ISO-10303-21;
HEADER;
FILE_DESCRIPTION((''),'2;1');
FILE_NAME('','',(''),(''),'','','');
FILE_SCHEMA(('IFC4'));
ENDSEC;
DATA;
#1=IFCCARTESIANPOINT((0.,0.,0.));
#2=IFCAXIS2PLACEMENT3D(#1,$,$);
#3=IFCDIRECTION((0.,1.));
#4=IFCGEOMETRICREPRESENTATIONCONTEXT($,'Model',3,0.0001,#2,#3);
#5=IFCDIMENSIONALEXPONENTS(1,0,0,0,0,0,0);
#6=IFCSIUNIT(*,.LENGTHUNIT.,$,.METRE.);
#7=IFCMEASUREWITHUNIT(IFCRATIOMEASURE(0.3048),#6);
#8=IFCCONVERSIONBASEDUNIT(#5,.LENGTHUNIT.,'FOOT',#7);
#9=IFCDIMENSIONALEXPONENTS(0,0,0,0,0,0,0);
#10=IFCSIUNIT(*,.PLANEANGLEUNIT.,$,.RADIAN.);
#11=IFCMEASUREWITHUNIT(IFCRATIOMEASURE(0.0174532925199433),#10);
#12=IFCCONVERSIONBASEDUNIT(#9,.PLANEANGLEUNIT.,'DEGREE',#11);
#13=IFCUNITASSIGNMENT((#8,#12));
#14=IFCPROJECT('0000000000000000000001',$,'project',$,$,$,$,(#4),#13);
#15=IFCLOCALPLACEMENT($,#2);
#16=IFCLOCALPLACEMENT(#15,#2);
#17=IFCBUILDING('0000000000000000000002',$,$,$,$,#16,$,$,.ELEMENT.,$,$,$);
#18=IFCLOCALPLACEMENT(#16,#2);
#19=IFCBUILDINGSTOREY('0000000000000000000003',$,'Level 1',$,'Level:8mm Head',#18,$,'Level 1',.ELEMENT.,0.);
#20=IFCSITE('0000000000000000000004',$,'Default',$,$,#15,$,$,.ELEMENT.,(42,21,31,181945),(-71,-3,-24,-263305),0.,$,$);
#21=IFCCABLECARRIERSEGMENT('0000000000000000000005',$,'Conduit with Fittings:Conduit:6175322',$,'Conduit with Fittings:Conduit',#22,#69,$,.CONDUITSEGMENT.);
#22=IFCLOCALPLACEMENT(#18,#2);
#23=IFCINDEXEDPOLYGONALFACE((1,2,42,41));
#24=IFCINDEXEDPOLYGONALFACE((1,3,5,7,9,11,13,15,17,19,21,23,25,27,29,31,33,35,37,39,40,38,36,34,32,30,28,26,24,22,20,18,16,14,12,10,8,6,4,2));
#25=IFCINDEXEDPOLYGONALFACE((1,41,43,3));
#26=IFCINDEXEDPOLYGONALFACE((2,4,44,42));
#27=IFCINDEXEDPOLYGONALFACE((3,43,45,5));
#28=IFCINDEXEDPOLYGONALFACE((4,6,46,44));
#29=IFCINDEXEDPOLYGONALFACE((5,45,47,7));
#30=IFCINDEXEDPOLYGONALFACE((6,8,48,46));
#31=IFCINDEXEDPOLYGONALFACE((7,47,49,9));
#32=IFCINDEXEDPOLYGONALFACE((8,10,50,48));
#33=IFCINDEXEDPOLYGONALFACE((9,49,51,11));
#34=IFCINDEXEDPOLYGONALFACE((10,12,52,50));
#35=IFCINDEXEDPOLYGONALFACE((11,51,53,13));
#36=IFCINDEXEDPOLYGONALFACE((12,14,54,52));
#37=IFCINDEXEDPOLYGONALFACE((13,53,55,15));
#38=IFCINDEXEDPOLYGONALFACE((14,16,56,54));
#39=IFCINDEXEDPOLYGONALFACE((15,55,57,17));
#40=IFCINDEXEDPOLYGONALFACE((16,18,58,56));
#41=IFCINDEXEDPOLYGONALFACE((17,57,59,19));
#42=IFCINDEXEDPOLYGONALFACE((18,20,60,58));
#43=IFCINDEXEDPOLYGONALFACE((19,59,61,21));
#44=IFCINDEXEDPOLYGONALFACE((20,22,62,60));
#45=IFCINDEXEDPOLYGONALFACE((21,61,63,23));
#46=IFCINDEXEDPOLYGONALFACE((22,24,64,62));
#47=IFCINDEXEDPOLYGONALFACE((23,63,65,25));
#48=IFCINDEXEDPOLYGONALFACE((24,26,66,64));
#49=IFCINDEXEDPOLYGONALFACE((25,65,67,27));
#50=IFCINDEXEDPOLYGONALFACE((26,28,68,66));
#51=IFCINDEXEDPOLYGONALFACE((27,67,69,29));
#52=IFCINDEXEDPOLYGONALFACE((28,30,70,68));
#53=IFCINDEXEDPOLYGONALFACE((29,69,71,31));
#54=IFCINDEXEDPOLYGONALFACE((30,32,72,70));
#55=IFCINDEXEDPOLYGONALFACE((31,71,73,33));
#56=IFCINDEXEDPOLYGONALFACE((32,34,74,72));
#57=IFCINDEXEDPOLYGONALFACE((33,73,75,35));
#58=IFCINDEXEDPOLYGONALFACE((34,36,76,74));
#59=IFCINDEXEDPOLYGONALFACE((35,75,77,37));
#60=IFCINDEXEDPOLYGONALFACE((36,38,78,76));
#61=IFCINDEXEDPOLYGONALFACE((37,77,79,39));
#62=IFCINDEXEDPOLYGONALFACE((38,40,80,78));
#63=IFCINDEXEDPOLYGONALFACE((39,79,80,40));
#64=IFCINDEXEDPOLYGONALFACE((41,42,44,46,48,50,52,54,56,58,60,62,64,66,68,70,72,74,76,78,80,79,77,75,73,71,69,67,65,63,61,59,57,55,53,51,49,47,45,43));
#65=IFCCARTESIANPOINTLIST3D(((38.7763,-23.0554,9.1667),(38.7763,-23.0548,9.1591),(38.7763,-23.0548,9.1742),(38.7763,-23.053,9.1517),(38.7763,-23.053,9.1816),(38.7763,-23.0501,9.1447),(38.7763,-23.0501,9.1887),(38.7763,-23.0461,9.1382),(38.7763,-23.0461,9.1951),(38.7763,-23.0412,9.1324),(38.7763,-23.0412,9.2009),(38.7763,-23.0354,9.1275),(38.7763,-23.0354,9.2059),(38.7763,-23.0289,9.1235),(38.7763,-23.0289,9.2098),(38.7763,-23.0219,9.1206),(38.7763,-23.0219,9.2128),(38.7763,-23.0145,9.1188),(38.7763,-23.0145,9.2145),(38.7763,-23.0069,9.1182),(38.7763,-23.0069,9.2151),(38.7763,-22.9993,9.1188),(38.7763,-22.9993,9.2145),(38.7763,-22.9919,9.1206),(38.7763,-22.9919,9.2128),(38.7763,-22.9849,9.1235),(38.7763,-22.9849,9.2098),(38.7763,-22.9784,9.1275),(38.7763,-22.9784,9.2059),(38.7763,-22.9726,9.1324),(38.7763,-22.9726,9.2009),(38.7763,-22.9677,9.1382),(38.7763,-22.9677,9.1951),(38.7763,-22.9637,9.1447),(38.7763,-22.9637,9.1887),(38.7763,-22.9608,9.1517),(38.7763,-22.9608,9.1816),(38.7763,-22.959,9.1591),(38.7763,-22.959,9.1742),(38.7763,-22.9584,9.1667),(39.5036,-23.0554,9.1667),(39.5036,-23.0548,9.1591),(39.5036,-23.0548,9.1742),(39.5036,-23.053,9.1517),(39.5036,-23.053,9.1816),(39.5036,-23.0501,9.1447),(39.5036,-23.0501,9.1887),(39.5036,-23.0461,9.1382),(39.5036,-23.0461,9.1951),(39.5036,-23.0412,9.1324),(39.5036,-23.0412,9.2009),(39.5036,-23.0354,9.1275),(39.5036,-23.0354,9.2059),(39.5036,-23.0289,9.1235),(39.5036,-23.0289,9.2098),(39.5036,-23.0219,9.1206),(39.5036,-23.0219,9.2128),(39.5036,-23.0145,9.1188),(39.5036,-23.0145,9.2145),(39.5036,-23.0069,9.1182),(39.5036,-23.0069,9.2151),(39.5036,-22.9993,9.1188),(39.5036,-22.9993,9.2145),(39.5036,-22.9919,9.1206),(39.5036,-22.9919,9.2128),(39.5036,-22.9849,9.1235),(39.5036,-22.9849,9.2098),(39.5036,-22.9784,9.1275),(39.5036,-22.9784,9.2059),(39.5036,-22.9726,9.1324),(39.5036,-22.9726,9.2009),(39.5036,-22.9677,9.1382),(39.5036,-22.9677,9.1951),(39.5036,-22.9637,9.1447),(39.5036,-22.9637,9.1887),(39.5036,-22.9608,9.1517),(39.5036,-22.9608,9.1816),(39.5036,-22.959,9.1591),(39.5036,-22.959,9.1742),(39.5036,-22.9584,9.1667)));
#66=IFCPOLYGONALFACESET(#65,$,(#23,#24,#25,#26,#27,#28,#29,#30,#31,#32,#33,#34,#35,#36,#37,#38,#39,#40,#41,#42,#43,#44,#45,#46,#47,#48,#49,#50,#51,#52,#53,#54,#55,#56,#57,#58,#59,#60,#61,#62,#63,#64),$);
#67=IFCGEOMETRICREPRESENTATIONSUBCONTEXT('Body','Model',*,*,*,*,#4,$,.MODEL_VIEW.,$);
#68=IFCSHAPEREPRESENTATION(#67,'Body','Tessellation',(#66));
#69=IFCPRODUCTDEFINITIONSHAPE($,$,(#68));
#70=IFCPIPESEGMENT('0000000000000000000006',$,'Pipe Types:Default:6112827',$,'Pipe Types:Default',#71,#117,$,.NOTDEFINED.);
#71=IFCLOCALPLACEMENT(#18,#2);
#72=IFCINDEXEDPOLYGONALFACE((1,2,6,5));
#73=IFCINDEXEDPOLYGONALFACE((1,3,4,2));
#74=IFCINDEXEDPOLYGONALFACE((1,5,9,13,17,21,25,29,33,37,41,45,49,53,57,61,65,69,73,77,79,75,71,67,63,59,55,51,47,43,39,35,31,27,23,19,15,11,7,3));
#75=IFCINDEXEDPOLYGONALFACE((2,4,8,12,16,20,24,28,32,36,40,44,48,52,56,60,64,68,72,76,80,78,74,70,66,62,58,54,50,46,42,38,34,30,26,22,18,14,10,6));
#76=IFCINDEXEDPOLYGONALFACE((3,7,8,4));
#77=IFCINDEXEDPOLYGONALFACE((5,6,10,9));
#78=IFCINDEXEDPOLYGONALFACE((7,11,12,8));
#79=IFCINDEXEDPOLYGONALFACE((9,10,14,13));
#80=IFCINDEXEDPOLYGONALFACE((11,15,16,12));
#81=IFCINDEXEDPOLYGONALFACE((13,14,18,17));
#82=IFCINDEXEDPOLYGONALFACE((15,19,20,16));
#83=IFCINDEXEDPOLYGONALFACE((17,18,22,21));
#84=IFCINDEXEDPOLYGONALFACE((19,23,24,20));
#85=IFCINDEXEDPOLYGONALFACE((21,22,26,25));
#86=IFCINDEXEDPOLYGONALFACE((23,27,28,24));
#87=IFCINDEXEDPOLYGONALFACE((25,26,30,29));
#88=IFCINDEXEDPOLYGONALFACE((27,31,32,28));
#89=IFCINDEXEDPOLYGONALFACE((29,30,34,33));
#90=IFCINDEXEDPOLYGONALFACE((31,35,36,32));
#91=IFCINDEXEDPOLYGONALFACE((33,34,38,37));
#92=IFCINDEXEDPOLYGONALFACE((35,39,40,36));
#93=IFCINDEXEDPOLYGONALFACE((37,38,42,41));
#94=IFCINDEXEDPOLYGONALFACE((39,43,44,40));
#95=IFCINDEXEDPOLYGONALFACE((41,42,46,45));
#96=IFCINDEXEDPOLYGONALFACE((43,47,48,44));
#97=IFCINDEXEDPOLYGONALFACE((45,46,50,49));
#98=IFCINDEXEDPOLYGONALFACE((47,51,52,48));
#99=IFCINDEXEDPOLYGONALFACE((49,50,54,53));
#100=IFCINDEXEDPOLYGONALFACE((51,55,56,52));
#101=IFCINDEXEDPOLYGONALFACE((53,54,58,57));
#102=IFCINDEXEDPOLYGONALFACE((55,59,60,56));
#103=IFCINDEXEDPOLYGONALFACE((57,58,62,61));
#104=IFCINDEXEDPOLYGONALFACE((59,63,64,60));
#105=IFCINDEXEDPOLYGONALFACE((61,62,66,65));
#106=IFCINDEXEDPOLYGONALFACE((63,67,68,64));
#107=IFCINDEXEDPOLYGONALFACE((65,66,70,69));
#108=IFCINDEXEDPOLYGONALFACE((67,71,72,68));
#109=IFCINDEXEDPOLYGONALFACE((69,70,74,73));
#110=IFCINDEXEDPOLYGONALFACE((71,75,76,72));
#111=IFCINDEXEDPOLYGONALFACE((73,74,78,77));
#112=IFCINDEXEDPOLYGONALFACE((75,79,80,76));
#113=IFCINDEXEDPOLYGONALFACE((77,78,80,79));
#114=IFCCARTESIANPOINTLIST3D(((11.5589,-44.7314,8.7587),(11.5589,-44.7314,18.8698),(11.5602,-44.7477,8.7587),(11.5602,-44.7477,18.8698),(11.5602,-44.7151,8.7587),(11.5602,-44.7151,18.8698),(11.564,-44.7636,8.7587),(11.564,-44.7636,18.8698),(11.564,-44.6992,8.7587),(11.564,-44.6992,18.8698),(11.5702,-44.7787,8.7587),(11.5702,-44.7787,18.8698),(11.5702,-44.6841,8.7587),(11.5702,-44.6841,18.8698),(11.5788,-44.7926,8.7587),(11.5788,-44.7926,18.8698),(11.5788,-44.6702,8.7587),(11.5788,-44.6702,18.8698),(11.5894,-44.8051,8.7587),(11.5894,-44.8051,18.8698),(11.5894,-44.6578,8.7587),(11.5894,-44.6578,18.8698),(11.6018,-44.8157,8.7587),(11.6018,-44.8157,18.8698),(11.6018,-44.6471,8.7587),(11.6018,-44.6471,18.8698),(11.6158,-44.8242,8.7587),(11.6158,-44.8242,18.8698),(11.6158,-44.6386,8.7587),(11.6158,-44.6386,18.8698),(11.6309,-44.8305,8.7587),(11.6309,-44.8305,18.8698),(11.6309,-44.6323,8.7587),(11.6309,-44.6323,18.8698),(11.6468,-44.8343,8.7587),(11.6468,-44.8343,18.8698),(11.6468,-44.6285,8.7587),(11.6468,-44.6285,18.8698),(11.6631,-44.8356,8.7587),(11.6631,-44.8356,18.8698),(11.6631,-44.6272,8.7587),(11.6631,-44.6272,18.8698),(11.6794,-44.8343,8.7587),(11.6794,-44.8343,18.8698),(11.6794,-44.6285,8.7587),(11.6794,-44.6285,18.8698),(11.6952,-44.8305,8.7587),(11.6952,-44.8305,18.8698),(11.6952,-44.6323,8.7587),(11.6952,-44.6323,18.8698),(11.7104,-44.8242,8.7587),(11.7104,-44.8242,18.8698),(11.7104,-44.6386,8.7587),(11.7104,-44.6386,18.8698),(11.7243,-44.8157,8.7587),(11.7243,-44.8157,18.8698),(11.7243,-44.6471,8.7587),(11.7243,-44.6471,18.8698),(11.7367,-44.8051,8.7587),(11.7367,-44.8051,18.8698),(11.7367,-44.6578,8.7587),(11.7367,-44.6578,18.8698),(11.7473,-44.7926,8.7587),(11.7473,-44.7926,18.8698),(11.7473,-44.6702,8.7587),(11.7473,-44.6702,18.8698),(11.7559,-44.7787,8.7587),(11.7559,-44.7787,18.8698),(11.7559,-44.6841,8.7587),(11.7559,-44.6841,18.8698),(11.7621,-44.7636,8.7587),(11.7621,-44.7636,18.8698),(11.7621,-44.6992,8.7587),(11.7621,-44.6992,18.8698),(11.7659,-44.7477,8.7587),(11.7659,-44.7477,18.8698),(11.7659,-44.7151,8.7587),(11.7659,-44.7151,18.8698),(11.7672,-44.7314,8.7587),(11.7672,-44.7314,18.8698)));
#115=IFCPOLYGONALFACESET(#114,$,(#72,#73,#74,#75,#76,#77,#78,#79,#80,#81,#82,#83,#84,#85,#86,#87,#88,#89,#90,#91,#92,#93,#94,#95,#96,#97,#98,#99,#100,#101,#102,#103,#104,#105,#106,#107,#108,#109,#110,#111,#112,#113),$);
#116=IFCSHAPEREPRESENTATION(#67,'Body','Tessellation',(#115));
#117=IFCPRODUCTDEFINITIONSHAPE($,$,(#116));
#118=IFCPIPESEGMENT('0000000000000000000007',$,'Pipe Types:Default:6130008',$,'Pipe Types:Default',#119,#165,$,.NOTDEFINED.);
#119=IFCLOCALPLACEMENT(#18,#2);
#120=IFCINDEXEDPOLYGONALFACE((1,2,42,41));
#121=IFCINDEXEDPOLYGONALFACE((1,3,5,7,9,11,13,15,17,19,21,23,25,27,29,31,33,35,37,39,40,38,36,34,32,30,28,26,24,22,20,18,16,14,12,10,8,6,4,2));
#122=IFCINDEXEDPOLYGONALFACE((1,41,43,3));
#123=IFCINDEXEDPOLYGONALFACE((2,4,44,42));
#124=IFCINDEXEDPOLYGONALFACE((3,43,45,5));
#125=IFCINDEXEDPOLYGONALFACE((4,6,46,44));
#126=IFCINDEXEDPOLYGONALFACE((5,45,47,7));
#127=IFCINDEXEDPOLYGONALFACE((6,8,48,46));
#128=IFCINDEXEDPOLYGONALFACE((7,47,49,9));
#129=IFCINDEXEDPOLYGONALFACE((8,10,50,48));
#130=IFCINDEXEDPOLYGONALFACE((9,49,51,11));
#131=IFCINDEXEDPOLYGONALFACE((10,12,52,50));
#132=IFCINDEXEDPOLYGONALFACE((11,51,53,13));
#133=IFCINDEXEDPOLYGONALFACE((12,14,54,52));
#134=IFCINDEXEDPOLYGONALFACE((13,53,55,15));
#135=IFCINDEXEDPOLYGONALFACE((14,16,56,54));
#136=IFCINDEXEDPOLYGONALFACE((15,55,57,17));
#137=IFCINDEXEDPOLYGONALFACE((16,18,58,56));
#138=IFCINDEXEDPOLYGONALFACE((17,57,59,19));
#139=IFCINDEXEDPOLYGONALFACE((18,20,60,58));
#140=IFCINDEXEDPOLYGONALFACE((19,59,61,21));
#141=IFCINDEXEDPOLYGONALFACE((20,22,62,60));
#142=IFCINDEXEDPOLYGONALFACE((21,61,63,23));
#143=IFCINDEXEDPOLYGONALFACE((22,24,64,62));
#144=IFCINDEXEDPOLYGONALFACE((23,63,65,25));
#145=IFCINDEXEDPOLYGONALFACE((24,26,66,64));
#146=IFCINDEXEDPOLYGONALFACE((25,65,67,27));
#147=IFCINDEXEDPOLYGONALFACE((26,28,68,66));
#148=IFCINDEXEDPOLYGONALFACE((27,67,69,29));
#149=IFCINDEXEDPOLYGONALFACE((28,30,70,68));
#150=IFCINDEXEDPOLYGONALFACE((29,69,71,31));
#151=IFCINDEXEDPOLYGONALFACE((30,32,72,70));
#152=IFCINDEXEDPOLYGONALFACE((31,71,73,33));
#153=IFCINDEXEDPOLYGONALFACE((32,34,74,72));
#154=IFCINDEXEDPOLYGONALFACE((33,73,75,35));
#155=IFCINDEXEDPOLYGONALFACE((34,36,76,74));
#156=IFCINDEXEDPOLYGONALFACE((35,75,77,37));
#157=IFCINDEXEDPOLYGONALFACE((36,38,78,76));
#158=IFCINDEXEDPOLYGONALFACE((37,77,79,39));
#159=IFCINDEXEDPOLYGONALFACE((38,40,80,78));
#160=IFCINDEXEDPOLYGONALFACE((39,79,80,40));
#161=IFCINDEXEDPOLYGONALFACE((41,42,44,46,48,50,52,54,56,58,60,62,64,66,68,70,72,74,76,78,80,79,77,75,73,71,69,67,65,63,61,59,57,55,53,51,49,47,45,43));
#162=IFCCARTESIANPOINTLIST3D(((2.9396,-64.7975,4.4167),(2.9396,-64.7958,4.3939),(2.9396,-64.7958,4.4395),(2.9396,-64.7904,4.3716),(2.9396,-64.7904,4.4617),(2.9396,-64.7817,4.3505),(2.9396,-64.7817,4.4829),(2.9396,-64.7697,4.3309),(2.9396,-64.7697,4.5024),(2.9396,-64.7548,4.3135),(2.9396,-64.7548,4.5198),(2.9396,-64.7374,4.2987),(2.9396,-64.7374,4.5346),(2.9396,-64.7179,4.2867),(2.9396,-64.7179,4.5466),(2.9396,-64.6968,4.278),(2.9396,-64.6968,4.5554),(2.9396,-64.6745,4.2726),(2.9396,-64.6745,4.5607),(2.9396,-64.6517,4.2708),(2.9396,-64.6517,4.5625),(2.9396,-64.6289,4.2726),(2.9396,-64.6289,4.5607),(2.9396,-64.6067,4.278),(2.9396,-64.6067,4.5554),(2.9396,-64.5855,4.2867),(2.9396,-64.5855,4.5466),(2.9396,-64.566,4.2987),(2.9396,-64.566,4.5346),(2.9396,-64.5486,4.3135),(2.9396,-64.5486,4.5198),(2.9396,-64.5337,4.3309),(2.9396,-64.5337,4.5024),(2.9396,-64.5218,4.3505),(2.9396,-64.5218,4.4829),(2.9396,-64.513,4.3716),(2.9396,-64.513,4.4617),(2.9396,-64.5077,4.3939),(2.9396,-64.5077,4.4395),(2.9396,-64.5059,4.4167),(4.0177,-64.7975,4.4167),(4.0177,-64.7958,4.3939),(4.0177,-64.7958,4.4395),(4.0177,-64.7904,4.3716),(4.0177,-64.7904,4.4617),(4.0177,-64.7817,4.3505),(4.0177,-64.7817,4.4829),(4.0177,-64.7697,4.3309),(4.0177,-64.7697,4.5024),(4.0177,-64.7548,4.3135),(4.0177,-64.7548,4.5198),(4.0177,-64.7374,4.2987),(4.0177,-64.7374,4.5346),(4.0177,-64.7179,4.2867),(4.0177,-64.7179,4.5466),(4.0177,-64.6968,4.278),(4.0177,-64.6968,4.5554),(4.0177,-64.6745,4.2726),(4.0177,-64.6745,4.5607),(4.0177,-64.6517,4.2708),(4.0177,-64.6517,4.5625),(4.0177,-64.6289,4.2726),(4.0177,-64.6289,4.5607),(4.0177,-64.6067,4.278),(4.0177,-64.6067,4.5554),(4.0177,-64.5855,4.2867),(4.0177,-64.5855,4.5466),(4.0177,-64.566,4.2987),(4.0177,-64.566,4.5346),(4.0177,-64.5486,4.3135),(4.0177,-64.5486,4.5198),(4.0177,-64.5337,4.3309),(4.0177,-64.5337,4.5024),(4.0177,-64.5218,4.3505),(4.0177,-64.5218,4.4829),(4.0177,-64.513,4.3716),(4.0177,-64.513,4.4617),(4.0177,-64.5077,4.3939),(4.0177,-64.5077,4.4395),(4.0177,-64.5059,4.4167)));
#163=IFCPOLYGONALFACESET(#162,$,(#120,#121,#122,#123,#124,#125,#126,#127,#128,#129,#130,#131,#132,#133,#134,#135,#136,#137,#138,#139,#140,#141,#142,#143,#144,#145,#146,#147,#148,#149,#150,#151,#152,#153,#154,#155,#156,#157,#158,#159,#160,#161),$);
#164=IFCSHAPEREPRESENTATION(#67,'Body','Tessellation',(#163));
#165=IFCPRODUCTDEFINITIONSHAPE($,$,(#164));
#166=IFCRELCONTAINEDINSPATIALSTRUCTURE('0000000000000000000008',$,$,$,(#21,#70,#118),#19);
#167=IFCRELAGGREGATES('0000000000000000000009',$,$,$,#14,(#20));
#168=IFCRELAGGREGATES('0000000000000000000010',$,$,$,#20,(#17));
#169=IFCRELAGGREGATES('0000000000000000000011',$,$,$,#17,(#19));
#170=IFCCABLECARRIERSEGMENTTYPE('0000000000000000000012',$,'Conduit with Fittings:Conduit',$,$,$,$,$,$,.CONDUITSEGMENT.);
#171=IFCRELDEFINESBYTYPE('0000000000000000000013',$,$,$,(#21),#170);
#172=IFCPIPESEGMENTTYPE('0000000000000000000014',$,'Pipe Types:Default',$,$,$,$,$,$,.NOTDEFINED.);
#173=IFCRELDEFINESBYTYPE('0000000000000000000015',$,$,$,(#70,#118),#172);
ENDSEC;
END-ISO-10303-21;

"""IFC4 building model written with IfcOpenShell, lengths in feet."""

from ifc_helpers import new_model, entity, si_unit, converted_unit, direction, frame, origin, place, context, subcontext, project, spatial, indexed_curve, outline, extrude, type_object, element, save


model = new_model("IFC4")

# Units and contexts
model_context = context("Model", 3, precision=0.0001, world=origin(), true_north=direction((0.0, 1.0)))
body_context = subcontext(model_context, "Body", "Model", "MODEL_VIEW")
ifc_project = project(units=[converted_unit("LENGTHUNIT", "FOOT", entity("IfcRatioMeasure", 0.3048), si_unit("LENGTHUNIT", "METRE"), dimensions=[1, 0, 0, 0, 0, 0, 0]), converted_unit("PLANEANGLEUNIT", "DEGREE", entity("IfcRatioMeasure", 0.0174532925199433), si_unit("PLANEANGLEUNIT", "RADIAN"), dimensions=[0, 0, 0, 0, 0, 0, 0])], contexts=[model_context])

# Site, building, storey
site_placement = place(None, origin())
site = spatial("IfcSite", under=ifc_project, at=site_placement, Name="Default", CompositionType="ELEMENT", RefLatitude=(42, 21, 31, 181945), RefLongitude=(-71, -3, -24, -263305), RefElevation=0.0)
building_placement = place(site_placement, origin())
building = spatial("IfcBuilding", under=site, at=building_placement, CompositionType="ELEMENT")
storey_placement = place(building_placement, origin())
storey = spatial("IfcBuildingStorey", under=building, at=storey_placement, Name="Level 1", ObjectType="Level:8mm Head", LongName="Level 1", CompositionType="ELEMENT", Elevation=0.0)

# Cable carrier segment
cable_carrier_segment_type_1 = type_object("IfcCableCarrierSegmentType", Name="Conduit with Fittings:Conduit", PredefinedType="CONDUITSEGMENT")
cable_carrier_segment_1_placement = place(storey_placement, origin())
element("IfcCableCarrierSegment", 1, at=cable_carrier_segment_1_placement, inside=storey, type_object=cable_carrier_segment_type_1, Name="Conduit with Fittings:Conduit:6175322", ObjectType="Conduit with Fittings:Conduit", PredefinedType="CONDUITSEGMENT", context=body_context, shape_type="SweptSolid", body=[
    extrude(outline(indexed_curve([(0.0485, 0.0), (0.0479, 0.0076), (0.0461, 0.015), (0.0432, 0.022), (0.0392, 0.0285), (0.0343, 0.0343), (0.0285, 0.0392), (0.022, 0.0432), (0.015, 0.0461), (0.0076, 0.0479), (0.0, 0.0485), (-0.0076, 0.0479), (-0.015, 0.0461), (-0.022, 0.0432), (-0.0285, 0.0392), (-0.0343, 0.0343), (-0.0392, 0.0285), (-0.0432, 0.022), (-0.0461, 0.015), (-0.0479, 0.0076), (-0.0485, 0.0), (-0.0479, -0.0076), (-0.0461, -0.015), (-0.0432, -0.022), (-0.0392, -0.0285), (-0.0343, -0.0343), (-0.0285, -0.0392), (-0.022, -0.0432), (-0.015, -0.0461), (-0.0076, -0.0479), (0.0, -0.0485), (0.0076, -0.0479), (0.015, -0.0461), (0.022, -0.0432), (0.0285, -0.0392), (0.0343, -0.0343), (0.0392, -0.0285), (0.0432, -0.022), (0.0461, -0.015), (0.0479, -0.0076), (0.0485, 0.0)], self_intersect=False)), frame((38.7763, -23.0069, 9.1667), z_axis=(1.0, 0.0, 0.0), x_axis=(0.0, -1.0, 0.0)), (0.0, 0.0, 1.0), 0.7272),
])

# Pipe segments
pipe_segment_type = type_object("IfcPipeSegmentType", Name="Pipe Types:Default", PredefinedType="NOTDEFINED")
pipe_segment_1_placement = place(storey_placement, origin())
element("IfcPipeSegment", 2, at=pipe_segment_1_placement, inside=storey, type_object=pipe_segment_type, Name="Pipe Types:Default:6112827", ObjectType="Pipe Types:Default", PredefinedType="NOTDEFINED", context=body_context, shape_type="SweptSolid", body=[
    extrude(outline(indexed_curve([(0.1042, 0.0), (0.1029, 0.0163), (0.0991, 0.0322), (0.0928, 0.0473), (0.0843, 0.0612), (0.0737, 0.0737), (0.0612, 0.0843), (0.0473, 0.0928), (0.0322, 0.0991), (0.0163, 0.1029), (0.0, 0.1042), (-0.0163, 0.1029), (-0.0322, 0.0991), (-0.0473, 0.0928), (-0.0612, 0.0843), (-0.0737, 0.0737), (-0.0843, 0.0612), (-0.0928, 0.0473), (-0.0991, 0.0322), (-0.1029, 0.0163), (-0.1042, 0.0), (-0.1029, -0.0163), (-0.0991, -0.0322), (-0.0928, -0.0473), (-0.0843, -0.0612), (-0.0737, -0.0737), (-0.0612, -0.0843), (-0.0473, -0.0928), (-0.0322, -0.0991), (-0.0163, -0.1029), (0.0, -0.1042), (0.0163, -0.1029), (0.0322, -0.0991), (0.0473, -0.0928), (0.0612, -0.0843), (0.0737, -0.0737), (0.0843, -0.0612), (0.0928, -0.0473), (0.0991, -0.0322), (0.1029, -0.0163), (0.1042, 0.0)], self_intersect=False)), frame((11.6631, -44.7314, 8.7587)), (0.0, 0.0, 1.0), 10.111),
])
pipe_segment_2_placement = place(storey_placement, origin())
element("IfcPipeSegment", 3, at=pipe_segment_2_placement, inside=storey, type_object=pipe_segment_type, Name="Pipe Types:Default:6130008", ObjectType="Pipe Types:Default", PredefinedType="NOTDEFINED", context=body_context, shape_type="SweptSolid", body=[
    extrude(outline(indexed_curve([(0.1458, 0.0), (0.144, 0.0228), (0.1387, 0.0451), (0.1299, 0.0662), (0.118, 0.0857), (0.1031, 0.1031), (0.0857, 0.118), (0.0662, 0.1299), (0.0451, 0.1387), (0.0228, 0.144), (0.0, 0.1458), (-0.0228, 0.144), (-0.0451, 0.1387), (-0.0662, 0.1299), (-0.0857, 0.118), (-0.1031, 0.1031), (-0.118, 0.0857), (-0.1299, 0.0662), (-0.1387, 0.0451), (-0.144, 0.0228), (-0.1458, 0.0), (-0.144, -0.0228), (-0.1387, -0.0451), (-0.1299, -0.0662), (-0.118, -0.0857), (-0.1031, -0.1031), (-0.0857, -0.118), (-0.0662, -0.1299), (-0.0451, -0.1387), (-0.0228, -0.144), (0.0, -0.1458), (0.0228, -0.144), (0.0451, -0.1387), (0.0662, -0.1299), (0.0857, -0.118), (0.1031, -0.1031), (0.118, -0.0857), (0.1299, -0.0662), (0.1387, -0.0451), (0.144, -0.0228), (0.1458, 0.0)], self_intersect=False)), frame((2.9396, -64.6517, 4.4167), z_axis=(1.0, 0.0, 0.0), x_axis=(0.0, 1.0, 0.0)), (0.0, 0.0, 1.0), 1.0781),
])

save(model, "model.ifc")
